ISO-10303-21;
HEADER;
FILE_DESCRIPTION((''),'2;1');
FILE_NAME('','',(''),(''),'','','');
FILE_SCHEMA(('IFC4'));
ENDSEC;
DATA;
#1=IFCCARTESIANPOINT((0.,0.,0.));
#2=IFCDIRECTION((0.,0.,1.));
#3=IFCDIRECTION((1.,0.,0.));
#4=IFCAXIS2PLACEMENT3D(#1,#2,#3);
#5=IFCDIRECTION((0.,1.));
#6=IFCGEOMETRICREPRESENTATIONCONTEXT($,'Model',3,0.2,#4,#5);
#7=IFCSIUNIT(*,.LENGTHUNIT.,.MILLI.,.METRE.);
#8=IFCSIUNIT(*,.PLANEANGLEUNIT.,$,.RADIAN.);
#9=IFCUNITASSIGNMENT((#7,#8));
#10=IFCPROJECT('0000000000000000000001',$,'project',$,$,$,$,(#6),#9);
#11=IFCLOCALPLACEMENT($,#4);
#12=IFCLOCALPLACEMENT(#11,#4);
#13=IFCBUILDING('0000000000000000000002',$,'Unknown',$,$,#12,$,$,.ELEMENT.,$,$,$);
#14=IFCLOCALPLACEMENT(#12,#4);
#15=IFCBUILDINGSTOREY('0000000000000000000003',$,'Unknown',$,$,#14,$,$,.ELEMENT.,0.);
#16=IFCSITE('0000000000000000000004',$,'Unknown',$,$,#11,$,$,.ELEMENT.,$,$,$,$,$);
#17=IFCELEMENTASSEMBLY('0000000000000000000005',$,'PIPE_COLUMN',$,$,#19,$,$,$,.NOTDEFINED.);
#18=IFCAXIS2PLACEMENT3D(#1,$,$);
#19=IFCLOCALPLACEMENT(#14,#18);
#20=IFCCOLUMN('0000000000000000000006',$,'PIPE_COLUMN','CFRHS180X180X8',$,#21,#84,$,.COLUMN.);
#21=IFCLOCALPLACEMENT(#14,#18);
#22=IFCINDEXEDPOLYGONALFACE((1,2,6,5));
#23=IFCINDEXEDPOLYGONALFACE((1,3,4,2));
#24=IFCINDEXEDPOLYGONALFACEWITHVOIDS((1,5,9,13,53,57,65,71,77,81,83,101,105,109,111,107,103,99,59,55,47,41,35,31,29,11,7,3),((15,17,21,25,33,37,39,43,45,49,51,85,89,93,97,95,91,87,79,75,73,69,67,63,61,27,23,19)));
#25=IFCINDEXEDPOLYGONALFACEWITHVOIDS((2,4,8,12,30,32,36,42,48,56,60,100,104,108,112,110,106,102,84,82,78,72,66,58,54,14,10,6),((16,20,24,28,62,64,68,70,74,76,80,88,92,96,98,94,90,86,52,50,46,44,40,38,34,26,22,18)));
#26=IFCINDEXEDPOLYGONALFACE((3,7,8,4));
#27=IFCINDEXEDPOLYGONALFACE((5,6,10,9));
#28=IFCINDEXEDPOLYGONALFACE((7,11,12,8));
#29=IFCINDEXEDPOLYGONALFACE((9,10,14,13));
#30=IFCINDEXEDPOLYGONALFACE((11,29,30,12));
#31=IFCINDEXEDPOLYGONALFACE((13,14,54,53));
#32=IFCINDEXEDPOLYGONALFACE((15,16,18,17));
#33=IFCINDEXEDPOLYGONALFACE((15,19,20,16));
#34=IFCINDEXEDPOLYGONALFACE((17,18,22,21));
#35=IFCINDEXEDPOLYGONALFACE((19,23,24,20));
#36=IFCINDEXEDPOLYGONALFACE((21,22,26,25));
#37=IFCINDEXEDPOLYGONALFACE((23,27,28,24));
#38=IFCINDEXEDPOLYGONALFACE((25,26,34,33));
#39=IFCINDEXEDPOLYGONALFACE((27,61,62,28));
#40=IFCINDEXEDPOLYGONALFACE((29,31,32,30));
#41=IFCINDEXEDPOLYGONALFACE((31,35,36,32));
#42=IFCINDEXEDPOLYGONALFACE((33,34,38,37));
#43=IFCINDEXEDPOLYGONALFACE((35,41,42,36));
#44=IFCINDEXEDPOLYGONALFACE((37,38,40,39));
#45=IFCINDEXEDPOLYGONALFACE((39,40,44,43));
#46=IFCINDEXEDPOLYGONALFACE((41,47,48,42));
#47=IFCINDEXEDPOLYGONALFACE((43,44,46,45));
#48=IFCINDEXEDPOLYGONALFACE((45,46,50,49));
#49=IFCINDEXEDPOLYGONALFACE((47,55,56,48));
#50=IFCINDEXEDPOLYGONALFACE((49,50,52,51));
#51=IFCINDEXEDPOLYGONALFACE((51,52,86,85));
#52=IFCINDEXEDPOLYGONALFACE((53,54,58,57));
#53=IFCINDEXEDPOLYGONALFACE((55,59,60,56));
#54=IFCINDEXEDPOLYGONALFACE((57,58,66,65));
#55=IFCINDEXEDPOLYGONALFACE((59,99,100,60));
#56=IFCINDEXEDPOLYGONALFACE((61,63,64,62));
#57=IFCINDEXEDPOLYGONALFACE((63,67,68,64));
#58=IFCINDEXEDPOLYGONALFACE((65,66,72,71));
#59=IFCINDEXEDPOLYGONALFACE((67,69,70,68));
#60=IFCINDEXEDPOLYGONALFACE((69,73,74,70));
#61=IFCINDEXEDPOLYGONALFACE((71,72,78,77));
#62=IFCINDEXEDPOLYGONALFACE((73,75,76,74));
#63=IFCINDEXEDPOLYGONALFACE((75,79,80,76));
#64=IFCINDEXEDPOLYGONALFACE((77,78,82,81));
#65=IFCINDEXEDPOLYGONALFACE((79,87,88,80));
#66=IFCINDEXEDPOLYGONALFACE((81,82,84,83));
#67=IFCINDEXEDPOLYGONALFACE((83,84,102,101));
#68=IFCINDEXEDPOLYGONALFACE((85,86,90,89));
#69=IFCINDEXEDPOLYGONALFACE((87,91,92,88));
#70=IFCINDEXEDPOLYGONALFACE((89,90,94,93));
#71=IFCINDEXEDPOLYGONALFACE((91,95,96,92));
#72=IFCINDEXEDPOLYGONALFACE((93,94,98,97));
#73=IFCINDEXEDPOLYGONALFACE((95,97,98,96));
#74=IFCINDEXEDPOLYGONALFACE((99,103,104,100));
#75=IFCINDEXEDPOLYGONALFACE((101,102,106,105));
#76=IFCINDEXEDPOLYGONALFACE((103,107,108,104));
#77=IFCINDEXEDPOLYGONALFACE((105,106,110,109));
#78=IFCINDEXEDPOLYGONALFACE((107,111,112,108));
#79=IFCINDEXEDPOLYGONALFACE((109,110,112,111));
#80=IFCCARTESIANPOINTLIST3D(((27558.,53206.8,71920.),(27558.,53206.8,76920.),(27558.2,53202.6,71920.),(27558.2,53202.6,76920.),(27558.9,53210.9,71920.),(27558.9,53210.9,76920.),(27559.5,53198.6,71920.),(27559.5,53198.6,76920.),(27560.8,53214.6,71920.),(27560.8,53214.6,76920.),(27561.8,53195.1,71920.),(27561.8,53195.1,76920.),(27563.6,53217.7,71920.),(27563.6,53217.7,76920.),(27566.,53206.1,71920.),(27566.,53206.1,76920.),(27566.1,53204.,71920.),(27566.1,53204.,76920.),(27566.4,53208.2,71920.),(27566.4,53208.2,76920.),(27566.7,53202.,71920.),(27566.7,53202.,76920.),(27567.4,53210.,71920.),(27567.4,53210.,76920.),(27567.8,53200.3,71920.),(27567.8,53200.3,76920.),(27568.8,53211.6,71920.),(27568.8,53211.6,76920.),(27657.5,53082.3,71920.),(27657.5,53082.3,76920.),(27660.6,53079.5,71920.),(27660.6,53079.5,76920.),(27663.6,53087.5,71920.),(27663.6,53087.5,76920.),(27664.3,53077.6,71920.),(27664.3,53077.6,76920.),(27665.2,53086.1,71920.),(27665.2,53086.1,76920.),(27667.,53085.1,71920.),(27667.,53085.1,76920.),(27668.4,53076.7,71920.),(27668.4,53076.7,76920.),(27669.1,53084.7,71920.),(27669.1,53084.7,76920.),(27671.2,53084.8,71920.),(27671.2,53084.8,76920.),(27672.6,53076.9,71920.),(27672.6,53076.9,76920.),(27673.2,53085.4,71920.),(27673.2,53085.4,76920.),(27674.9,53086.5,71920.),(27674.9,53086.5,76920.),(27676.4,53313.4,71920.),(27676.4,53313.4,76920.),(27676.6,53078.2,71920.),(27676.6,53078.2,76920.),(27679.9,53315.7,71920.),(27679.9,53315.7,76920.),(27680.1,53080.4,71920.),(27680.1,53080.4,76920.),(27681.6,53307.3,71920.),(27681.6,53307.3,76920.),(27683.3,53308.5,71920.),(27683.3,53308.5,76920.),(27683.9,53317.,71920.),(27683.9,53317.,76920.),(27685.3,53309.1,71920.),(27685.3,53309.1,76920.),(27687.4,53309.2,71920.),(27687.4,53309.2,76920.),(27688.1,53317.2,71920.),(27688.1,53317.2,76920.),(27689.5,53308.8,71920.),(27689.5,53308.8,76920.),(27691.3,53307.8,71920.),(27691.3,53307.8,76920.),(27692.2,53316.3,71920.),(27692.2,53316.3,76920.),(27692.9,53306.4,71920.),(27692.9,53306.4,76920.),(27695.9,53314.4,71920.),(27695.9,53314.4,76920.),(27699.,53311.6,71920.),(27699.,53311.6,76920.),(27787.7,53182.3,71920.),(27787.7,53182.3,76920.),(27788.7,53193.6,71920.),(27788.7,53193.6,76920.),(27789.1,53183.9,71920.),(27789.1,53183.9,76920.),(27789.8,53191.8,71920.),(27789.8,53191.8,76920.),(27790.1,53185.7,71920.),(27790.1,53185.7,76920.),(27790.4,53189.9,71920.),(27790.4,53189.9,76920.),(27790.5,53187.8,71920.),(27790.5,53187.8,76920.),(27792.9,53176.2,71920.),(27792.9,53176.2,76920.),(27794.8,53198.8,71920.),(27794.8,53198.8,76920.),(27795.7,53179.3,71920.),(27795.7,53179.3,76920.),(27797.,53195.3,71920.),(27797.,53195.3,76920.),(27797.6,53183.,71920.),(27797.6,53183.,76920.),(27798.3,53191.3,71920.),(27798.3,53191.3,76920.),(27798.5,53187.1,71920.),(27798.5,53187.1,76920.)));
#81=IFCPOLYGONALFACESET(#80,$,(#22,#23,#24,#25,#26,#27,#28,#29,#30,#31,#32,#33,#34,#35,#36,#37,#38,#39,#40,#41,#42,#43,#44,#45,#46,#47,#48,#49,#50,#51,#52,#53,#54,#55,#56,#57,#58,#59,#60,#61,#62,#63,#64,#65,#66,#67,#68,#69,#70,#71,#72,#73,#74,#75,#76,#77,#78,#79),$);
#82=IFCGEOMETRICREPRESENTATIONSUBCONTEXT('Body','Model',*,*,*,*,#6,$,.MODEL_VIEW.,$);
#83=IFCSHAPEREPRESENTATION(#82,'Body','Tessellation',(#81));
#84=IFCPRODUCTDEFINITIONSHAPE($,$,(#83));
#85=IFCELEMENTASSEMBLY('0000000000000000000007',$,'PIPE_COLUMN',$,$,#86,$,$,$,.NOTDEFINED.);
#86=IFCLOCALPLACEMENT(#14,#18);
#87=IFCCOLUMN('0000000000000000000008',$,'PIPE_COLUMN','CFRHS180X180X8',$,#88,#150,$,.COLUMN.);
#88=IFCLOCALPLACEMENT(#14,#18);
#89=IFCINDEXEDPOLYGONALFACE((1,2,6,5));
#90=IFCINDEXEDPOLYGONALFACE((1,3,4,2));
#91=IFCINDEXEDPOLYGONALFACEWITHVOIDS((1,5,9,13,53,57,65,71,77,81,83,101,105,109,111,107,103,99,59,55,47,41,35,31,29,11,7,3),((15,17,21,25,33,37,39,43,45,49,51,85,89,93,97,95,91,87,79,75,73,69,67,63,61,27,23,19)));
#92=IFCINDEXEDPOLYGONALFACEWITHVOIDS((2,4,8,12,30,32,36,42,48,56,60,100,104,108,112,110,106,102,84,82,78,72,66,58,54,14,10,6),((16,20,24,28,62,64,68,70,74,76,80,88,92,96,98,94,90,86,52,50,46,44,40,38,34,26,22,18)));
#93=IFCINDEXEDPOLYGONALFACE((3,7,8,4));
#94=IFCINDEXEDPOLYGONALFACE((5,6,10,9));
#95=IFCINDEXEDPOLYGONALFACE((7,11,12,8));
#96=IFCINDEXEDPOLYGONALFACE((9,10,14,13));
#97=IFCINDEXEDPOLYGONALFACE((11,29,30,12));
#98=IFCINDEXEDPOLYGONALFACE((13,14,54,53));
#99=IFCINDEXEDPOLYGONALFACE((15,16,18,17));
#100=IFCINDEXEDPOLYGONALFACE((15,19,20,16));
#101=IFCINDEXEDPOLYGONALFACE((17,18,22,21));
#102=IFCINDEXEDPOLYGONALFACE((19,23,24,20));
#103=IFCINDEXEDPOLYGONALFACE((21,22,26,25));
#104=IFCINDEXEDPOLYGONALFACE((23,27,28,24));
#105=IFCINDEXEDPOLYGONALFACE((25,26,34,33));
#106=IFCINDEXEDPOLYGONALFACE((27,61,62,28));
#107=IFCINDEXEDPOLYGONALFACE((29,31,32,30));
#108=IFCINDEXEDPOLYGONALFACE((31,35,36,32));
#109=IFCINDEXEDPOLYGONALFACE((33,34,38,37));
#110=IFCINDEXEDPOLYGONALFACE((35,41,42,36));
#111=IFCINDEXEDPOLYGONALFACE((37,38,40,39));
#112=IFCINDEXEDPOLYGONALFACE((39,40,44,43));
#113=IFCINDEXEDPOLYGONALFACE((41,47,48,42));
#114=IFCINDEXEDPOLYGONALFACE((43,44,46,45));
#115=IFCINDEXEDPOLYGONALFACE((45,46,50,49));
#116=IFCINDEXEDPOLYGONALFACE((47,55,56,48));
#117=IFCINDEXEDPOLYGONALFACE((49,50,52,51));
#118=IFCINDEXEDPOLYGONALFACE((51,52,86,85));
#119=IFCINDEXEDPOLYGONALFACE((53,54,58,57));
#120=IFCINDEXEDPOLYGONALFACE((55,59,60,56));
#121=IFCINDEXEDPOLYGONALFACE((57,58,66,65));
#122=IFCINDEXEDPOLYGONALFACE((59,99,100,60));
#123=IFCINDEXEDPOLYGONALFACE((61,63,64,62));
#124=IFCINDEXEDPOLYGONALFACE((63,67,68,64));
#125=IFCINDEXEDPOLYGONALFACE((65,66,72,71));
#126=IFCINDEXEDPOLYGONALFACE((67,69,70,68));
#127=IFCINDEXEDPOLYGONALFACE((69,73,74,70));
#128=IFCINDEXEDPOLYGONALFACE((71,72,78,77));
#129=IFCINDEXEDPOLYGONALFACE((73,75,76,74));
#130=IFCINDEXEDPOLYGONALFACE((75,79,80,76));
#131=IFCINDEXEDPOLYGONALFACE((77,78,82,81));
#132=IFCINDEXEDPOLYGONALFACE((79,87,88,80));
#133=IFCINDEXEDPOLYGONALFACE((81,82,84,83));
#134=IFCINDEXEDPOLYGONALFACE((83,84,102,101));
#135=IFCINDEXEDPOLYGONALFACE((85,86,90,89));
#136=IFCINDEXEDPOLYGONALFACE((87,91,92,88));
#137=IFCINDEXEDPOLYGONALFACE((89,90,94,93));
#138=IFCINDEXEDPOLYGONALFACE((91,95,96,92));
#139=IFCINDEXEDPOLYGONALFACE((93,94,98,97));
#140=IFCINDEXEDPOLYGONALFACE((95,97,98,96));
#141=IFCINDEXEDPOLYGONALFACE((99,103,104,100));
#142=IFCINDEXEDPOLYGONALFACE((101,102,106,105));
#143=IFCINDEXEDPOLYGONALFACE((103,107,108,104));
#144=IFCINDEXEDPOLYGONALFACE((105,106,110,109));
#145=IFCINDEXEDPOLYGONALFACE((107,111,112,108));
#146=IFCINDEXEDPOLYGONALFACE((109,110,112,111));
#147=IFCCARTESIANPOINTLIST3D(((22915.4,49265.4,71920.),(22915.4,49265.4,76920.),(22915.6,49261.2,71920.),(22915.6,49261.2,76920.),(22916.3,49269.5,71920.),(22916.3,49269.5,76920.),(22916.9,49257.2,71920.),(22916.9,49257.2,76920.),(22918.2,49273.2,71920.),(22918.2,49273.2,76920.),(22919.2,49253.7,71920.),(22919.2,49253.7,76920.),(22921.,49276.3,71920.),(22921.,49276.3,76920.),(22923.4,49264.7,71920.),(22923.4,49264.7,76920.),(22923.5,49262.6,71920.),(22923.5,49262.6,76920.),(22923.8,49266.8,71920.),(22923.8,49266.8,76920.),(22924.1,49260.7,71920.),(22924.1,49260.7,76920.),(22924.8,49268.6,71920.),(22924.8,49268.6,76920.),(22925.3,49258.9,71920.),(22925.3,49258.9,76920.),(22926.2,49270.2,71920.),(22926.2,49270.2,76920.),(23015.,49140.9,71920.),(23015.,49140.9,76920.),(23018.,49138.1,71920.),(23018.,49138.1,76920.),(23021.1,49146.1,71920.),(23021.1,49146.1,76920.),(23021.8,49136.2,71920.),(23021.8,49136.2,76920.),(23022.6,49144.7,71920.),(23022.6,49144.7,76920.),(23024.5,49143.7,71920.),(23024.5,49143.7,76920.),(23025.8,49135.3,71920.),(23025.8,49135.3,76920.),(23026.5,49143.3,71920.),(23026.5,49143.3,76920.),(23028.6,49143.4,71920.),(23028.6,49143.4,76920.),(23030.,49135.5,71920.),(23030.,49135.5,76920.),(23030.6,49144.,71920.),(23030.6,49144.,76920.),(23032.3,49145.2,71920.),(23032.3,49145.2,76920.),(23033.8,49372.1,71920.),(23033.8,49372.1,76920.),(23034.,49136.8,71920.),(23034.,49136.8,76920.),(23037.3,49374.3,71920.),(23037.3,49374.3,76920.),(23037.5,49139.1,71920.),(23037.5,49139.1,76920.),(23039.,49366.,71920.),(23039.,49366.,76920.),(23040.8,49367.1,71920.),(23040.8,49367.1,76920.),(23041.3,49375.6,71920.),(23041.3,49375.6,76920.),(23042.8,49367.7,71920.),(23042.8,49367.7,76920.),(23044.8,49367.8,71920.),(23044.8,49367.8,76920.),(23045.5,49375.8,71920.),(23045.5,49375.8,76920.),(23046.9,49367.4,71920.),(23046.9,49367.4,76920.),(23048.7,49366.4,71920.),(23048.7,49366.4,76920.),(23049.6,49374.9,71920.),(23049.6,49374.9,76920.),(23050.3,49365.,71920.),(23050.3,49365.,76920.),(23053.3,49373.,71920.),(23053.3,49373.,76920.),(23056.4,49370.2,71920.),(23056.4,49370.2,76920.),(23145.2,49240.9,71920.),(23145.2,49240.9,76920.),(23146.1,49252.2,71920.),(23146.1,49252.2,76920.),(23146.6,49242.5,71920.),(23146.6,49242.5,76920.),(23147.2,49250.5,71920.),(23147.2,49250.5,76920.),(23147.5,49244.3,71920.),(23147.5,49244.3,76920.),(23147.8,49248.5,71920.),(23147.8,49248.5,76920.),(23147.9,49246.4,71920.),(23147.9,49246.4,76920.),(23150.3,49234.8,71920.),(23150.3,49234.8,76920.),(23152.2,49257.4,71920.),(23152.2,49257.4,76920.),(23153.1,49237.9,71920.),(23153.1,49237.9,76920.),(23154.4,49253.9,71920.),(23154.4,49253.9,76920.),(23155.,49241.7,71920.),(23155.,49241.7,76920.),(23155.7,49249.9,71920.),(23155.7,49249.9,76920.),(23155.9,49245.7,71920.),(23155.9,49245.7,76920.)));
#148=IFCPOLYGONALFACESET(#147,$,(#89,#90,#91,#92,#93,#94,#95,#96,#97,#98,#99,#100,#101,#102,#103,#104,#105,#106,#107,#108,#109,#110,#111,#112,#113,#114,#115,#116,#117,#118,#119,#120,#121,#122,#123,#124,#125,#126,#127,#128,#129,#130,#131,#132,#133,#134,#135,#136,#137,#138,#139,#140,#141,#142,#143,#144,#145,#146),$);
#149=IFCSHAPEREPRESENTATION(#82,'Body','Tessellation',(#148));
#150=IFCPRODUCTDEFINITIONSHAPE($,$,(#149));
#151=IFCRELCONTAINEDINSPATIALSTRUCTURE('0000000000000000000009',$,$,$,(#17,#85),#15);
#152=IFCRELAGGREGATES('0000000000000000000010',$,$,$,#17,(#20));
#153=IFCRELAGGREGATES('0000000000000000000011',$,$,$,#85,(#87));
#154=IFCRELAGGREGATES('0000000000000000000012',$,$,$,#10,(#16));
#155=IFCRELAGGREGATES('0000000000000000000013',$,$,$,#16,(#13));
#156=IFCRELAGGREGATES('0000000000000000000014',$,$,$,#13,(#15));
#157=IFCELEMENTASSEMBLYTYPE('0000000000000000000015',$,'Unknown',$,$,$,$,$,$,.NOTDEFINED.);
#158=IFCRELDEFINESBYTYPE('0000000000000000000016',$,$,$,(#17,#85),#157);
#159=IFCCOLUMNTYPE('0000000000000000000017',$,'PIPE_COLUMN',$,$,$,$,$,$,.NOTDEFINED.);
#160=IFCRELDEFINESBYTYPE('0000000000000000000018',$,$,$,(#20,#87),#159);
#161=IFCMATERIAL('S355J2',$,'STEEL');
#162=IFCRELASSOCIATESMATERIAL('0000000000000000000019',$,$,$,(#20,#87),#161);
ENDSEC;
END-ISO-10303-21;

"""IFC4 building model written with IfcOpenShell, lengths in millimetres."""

from ifc_helpers import new_model, si_unit, direction, frame, origin_with_axes, origin_2d_with_axis, place, context, subcontext, project, spatial, hollow_rectangle, extrude, material, material_profile, profile_set, profile_usage, type_object, element, aggregate, save


model = new_model("IFC4")

# Units and contexts
model_context = context("Model", 3, precision=0.2, world=origin_with_axes(), true_north=direction((0.0, 1.0)))
body_context = subcontext(model_context, "Body", "Model", "MODEL_VIEW")
ifc_project = project(units=[si_unit("LENGTHUNIT", "METRE", prefix="MILLI"), si_unit("PLANEANGLEUNIT", "RADIAN")], contexts=[model_context])

# Site, building, storey
site_placement = place(None, origin_with_axes())
site = spatial("IfcSite", under=ifc_project, at=site_placement, Name="Unknown", CompositionType="ELEMENT")
building_placement = place(site_placement, origin_with_axes())
building = spatial("IfcBuilding", under=site, at=building_placement, Name="Unknown", CompositionType="ELEMENT")
storey_placement = place(building_placement, origin_with_axes())
storey = spatial("IfcBuildingStorey", under=building, at=storey_placement, Name="Unknown", CompositionType="ELEMENT", Elevation=0.0)

# Element assemblies, columns
element_assembly_type = type_object("IfcElementAssemblyType", Name="Unknown", PredefinedType="NOTDEFINED")
ifc_material_1 = material(Name="S355J2", Category="STEEL")
ifc_material_profile_1 = material_profile(ifc_material_1, hollow_rectangle(XDim=180.0, YDim=180.0, WallThickness=8.0, InnerFilletRadius=8.0, OuterFilletRadius=16.0, at=origin_2d_with_axis()), Name="CFRHS180X180X8")
ifc_profile_set_1 = profile_set([ifc_material_profile_1])
ifc_profile_usage_1 = profile_usage(ifc_profile_set_1, cardinal=6)
column_type_1 = type_object("IfcColumnType", Name="PIPE_COLUMN")
assembly_1_placement = place(storey_placement, frame((27678.3, 53196.9, 71920.0), z_axis=(-0.762329, -0.64719, 0.0), x_axis=(0.0, 0.0, 1.0)))
assembly_1 = element("IfcElementAssembly", 1, at=assembly_1_placement, inside=storey, type_object=element_assembly_type, Name="PIPE_COLUMN", PredefinedType="NOTDEFINED")
column_1_placement = place(assembly_1_placement, origin_with_axes())
column_1 = element("IfcColumn", 2, at=column_1_placement, type_object=column_type_1, material=ifc_profile_usage_1, Name="PIPE_COLUMN", Description="CFRHS180X180X8", PredefinedType="COLUMN", context=body_context, shape_type="SolidModel", body=[
    extrude(hollow_rectangle(XDim=180.0, YDim=180.0, WallThickness=8.0, InnerFilletRadius=8.0, OuterFilletRadius=16.0, at=origin_2d_with_axis()), frame((0.0, 0.0, 0.0), z_axis=(-1.0, 0.0, 0.0), x_axis=(0.0, 0.0, 1.0)), (0.0, 0.0, -1.0), 5000.0),
])
aggregate(assembly_1, [column_1])
assembly_2_placement = place(storey_placement, frame((23035.7, 49255.6, 71920.0), z_axis=(-0.762329, -0.64719, 0.0), x_axis=(0.0, 0.0, 1.0)))
assembly_2 = element("IfcElementAssembly", 3, at=assembly_2_placement, inside=storey, type_object=element_assembly_type, Name="PIPE_COLUMN", PredefinedType="NOTDEFINED")
ifc_profile_usage_2 = profile_usage(ifc_profile_set_1, cardinal=3)
column_2_placement = place(assembly_2_placement, origin_with_axes())
column_2 = element("IfcColumn", 4, at=column_2_placement, type_object=column_type_1, material=ifc_profile_usage_2, Name="PIPE_COLUMN", Description="CFRHS180X180X8", PredefinedType="COLUMN", context=body_context, shape_type="SolidModel", body=[
    extrude(hollow_rectangle(XDim=180.0, YDim=180.0, WallThickness=8.0, InnerFilletRadius=8.0, OuterFilletRadius=16.0, at=origin_2d_with_axis()), frame((0.0, 0.0, 0.0), z_axis=(-1.0, 0.0, 0.0), x_axis=(0.0, 0.0, 1.0)), (0.0, 0.0, -1.0), 5000.0),
])
aggregate(assembly_2, [column_2])

save(model, "model.ifc")
